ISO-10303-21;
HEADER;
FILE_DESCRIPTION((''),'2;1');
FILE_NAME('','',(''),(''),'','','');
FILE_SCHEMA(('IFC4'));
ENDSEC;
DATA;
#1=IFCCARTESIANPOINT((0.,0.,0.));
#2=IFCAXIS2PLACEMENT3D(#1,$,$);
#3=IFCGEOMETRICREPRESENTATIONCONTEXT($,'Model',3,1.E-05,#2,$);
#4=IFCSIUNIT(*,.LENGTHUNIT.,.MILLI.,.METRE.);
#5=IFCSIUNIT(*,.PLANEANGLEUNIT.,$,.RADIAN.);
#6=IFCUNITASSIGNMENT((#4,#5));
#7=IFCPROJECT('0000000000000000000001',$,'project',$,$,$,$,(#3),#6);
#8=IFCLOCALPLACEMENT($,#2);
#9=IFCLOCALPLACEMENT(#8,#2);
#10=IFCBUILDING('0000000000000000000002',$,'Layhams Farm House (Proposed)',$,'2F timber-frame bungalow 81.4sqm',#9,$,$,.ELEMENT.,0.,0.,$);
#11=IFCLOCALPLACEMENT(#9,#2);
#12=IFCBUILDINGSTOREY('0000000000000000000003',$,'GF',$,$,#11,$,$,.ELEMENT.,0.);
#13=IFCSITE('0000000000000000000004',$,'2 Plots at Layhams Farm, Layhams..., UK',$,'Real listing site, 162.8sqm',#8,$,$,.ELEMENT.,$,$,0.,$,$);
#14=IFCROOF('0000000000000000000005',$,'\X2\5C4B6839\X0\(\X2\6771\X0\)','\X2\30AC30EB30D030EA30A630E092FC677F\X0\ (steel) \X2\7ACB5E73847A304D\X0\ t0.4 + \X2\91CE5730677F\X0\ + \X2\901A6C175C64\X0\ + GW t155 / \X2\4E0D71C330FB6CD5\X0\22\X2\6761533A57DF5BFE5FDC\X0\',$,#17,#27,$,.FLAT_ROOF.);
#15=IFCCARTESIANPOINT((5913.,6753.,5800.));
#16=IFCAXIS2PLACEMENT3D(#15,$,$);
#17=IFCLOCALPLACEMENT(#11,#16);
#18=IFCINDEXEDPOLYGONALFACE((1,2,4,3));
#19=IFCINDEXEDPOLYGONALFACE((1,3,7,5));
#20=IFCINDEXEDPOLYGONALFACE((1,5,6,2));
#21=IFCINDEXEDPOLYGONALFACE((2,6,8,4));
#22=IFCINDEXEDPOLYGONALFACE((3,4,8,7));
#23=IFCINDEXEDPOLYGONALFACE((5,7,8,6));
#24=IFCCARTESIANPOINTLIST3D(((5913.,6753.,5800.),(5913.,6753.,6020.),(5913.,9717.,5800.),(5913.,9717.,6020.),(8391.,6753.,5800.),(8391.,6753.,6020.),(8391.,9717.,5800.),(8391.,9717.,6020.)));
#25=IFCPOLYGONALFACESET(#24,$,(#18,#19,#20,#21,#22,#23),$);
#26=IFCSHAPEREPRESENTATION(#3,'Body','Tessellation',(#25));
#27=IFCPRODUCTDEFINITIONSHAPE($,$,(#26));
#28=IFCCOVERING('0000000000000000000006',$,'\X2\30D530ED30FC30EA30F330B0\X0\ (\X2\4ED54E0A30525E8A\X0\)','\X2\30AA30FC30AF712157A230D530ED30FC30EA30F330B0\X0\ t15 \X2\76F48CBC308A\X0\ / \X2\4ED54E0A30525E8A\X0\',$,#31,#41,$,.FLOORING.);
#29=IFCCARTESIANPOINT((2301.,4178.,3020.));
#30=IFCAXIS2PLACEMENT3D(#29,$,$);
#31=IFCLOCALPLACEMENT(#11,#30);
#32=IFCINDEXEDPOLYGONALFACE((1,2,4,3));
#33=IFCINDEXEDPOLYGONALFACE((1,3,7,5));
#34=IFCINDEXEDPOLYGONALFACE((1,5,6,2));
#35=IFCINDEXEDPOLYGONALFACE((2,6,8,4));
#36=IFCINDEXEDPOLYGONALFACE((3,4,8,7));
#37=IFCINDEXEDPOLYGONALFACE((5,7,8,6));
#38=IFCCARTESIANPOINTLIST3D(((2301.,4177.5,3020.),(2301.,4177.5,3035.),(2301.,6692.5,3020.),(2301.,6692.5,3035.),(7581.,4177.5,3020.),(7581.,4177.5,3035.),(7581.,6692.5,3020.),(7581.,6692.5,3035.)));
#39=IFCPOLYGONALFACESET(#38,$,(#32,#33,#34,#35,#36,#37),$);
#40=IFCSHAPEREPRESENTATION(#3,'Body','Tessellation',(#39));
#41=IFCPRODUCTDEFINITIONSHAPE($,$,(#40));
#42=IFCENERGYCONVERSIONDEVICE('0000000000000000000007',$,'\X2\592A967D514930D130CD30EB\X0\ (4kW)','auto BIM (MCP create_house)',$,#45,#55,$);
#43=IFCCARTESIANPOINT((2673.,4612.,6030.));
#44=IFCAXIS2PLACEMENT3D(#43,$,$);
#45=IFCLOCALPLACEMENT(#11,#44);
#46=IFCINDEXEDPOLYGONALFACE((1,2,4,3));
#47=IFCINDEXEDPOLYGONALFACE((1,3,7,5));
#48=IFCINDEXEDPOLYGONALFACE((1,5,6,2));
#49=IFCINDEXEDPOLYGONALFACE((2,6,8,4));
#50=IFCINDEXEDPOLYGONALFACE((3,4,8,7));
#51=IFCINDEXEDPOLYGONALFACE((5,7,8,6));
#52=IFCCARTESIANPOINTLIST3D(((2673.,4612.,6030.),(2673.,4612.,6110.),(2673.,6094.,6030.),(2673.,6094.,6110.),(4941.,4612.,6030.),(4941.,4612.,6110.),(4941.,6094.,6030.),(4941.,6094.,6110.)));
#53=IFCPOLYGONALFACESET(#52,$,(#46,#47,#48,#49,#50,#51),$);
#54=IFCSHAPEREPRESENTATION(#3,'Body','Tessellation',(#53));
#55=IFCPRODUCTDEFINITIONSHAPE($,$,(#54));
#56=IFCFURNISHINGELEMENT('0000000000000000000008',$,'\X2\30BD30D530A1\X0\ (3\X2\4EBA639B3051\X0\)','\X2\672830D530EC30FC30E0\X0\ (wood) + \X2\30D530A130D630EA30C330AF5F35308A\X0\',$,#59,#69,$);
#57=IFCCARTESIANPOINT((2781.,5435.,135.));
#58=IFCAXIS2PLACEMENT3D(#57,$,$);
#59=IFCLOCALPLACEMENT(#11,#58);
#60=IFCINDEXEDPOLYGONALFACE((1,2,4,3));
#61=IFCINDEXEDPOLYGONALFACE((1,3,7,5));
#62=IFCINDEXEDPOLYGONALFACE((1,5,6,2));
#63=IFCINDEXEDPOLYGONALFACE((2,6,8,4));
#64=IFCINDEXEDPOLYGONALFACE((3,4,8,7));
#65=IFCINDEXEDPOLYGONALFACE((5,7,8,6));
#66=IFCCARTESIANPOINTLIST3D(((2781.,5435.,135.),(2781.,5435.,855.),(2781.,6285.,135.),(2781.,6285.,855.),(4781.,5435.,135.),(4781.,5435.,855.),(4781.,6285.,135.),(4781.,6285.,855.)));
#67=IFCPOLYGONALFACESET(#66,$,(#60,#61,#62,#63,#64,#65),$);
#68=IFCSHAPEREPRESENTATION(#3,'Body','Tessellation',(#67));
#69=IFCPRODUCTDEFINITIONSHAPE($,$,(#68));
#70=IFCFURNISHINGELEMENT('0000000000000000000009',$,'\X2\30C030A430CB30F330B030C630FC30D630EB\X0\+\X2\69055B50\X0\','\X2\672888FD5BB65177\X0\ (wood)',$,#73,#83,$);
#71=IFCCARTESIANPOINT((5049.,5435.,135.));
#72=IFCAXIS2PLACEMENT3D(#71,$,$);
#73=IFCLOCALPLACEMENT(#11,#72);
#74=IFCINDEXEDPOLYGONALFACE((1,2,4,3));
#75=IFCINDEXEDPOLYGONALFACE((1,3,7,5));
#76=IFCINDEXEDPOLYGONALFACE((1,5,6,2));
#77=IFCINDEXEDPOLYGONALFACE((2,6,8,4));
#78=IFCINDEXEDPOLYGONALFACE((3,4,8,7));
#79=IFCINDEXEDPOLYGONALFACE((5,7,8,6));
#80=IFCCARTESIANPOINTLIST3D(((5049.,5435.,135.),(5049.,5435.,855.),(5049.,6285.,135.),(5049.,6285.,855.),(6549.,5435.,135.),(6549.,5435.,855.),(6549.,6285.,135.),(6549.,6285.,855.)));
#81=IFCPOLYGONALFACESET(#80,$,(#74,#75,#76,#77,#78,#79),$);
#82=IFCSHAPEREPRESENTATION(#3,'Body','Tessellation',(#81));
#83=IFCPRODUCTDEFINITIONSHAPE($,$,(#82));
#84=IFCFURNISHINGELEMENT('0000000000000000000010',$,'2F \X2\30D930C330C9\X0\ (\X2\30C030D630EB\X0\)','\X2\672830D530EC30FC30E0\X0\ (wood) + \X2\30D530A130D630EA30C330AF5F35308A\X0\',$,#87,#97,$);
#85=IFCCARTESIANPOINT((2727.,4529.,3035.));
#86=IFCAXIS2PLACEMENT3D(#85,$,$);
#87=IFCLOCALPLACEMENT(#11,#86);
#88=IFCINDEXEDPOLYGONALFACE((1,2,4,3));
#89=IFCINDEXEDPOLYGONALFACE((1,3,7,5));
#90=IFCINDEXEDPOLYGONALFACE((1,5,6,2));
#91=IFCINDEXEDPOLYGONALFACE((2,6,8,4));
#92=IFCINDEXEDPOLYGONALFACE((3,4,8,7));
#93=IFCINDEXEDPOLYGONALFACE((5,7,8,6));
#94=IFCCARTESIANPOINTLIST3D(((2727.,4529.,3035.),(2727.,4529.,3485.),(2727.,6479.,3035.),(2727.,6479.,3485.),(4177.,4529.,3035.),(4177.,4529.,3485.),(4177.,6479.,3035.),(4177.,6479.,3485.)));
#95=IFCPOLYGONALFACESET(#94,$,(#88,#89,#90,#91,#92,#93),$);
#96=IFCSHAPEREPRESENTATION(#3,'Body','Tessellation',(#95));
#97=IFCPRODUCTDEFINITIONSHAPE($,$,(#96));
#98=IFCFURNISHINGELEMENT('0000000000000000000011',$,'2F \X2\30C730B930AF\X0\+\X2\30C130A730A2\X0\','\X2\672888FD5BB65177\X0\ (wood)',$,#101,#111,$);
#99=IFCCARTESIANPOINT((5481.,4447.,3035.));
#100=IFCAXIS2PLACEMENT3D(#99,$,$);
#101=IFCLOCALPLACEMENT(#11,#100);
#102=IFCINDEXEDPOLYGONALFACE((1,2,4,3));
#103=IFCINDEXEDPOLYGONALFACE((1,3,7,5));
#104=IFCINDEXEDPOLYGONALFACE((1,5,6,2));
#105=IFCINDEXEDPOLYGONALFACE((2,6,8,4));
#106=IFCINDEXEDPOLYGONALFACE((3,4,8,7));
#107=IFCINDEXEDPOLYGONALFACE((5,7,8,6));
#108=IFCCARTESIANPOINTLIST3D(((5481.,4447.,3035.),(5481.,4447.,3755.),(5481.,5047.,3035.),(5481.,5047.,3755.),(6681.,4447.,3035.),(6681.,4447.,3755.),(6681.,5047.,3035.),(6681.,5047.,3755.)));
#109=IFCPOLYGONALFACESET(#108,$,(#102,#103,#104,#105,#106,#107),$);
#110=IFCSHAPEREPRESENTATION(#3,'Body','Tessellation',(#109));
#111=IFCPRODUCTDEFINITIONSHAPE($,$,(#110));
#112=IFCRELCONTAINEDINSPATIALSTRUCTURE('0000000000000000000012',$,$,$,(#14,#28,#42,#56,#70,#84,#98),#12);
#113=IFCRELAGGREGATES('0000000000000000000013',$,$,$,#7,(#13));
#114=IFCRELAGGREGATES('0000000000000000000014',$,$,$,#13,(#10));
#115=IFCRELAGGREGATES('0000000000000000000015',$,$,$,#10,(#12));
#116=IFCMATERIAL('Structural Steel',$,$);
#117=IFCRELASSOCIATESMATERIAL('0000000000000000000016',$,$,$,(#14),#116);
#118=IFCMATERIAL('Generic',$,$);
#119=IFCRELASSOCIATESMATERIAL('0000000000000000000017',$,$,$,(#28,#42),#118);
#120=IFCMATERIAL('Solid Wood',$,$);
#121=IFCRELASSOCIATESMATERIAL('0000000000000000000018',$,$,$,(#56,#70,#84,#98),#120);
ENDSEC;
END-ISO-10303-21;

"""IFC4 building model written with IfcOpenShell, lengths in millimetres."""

from ifc_helpers import new_model, si_unit, frame, frame_2d, origin, place, context, project, spatial, rectangle, extrude, material, element, save


model = new_model("IFC4")

# Units and contexts
model_context = context("Model", 3, precision=1e-05, world=origin())
ifc_project = project(units=[si_unit("LENGTHUNIT", "METRE", prefix="MILLI"), si_unit("PLANEANGLEUNIT", "RADIAN")], contexts=[model_context])

# Site, building, storey
site_placement = place(None, origin())
site = spatial("IfcSite", under=ifc_project, at=site_placement, Name="2 Plots at Layhams Farm, Layhams..., UK", ObjectType="Real listing site, 162.8sqm", CompositionType="ELEMENT", RefElevation=0.0)
building_placement = place(site_placement, origin())
building = spatial("IfcBuilding", under=site, at=building_placement, Name="Layhams Farm House (Proposed)", ObjectType="2F timber-frame bungalow 81.4sqm", CompositionType="ELEMENT", ElevationOfRefHeight=0.0, ElevationOfTerrain=0.0)
storey_placement = place(building_placement, origin())
storey = spatial("IfcBuildingStorey", under=building, at=storey_placement, Name="GF", CompositionType="ELEMENT", Elevation=0.0)

# Shared definitions
ifc_material_1 = material(Name="Solid Wood")

# Roof
ifc_material_2 = material(Name="Structural Steel")
roof_1_placement = place(storey_placement, frame((5913.0, 6753.0, 5800.0)))
element("IfcRoof", 1, at=roof_1_placement, inside=storey, material=ifc_material_2, Name="屋根(東)", Description="ガルバリウム鋼板 (steel) 立平葺き t0.4 + 野地板 + 通気層 + GW t155 / 不燃・法22条区域対応", PredefinedType="FLAT_ROOF", context=model_context, shape_type="SweptSolid", body=[
    extrude(rectangle(XDim=2478.0, YDim=2964.0, at=frame_2d((1239.0, 1482.0))), frame((5913.0, 6753.0, 5800.0)), (0.0, 0.0, 1.0), 220.0),
])

# Covering
ifc_material_3 = material(Name="Generic")
covering_placement = place(storey_placement, frame((2301.0, 4178.0, 3020.0)))
element("IfcCovering", 2, at=covering_placement, inside=storey, material=ifc_material_3, Name="フローリング (仕上げ床)", Description="オーク無垢フローリング t15 直貼り / 仕上げ床", PredefinedType="FLOORING", context=model_context, shape_type="SweptSolid", body=[
    extrude(rectangle(XDim=5280.0, YDim=2515.0, at=frame_2d((2640.0, 1257.0))), frame((2301.0, 4178.0, 3020.0)), (0.0, 0.0, 1.0), 15.0),
])

# Energy conversion device
energy_conversion_device_placement = place(storey_placement, frame((2673.0, 4612.0, 6030.0)))
element("IfcEnergyConversionDevice", 3, at=energy_conversion_device_placement, inside=storey, material=ifc_material_3, Name="太陽光パネル (4kW)", Description="auto BIM (MCP create_house)", context=model_context, shape_type="SweptSolid", body=[
    extrude(rectangle(XDim=2268.0, YDim=1482.0, at=frame_2d((1134.0, 741.0))), frame((2673.0, 4612.0, 6030.0)), (0.0, 0.0, 1.0), 80.0),
])

# Furnishing elements
furnishing_1_placement = place(storey_placement, frame((2781.0, 5435.0, 135.0)))
element("IfcFurnishingElement", 4, at=furnishing_1_placement, inside=storey, material=ifc_material_1, Name="ソファ (3人掛け)", Description="木フレーム (wood) + ファブリック張り", context=model_context, shape_type="SweptSolid", body=[
    extrude(rectangle(XDim=2000.0, YDim=850.0, at=frame_2d((1000.0, 425.0))), frame((2781.0, 5435.0, 135.0)), (0.0, 0.0, 1.0), 720.0),
])
furnishing_2_placement = place(storey_placement, frame((5049.0, 5435.0, 135.0)))
element("IfcFurnishingElement", 5, at=furnishing_2_placement, inside=storey, material=ifc_material_1, Name="ダイニングテーブル+椅子", Description="木製家具 (wood)", context=model_context, shape_type="SweptSolid", body=[
    extrude(rectangle(XDim=1500.0, YDim=850.0, at=frame_2d((750.0, 425.0))), frame((5049.0, 5435.0, 135.0)), (0.0, 0.0, 1.0), 720.0),
])
furnishing_3_placement = place(storey_placement, frame((2727.0, 4529.0, 3035.0)))
element("IfcFurnishingElement", 6, at=furnishing_3_placement, inside=storey, material=ifc_material_1, Name="2F ベッド (ダブル)", Description="木フレーム (wood) + ファブリック張り", context=model_context, shape_type="SweptSolid", body=[
    extrude(rectangle(XDim=1450.0, YDim=1950.0, at=frame_2d((725.0, 975.0))), frame((2727.0, 4529.0, 3035.0)), (0.0, 0.0, 1.0), 450.0),
])
furnishing_4_placement = place(storey_placement, frame((5481.0, 4447.0, 3035.0)))
element("IfcFurnishingElement", 7, at=furnishing_4_placement, inside=storey, material=ifc_material_1, Name="2F デスク+チェア", Description="木製家具 (wood)", context=model_context, shape_type="SweptSolid", body=[
    extrude(rectangle(XDim=1200.0, YDim=600.0, at=frame_2d((600.0, 300.0))), frame((5481.0, 4447.0, 3035.0)), (0.0, 0.0, 1.0), 720.0),
])

save(model, "model.ifc")
